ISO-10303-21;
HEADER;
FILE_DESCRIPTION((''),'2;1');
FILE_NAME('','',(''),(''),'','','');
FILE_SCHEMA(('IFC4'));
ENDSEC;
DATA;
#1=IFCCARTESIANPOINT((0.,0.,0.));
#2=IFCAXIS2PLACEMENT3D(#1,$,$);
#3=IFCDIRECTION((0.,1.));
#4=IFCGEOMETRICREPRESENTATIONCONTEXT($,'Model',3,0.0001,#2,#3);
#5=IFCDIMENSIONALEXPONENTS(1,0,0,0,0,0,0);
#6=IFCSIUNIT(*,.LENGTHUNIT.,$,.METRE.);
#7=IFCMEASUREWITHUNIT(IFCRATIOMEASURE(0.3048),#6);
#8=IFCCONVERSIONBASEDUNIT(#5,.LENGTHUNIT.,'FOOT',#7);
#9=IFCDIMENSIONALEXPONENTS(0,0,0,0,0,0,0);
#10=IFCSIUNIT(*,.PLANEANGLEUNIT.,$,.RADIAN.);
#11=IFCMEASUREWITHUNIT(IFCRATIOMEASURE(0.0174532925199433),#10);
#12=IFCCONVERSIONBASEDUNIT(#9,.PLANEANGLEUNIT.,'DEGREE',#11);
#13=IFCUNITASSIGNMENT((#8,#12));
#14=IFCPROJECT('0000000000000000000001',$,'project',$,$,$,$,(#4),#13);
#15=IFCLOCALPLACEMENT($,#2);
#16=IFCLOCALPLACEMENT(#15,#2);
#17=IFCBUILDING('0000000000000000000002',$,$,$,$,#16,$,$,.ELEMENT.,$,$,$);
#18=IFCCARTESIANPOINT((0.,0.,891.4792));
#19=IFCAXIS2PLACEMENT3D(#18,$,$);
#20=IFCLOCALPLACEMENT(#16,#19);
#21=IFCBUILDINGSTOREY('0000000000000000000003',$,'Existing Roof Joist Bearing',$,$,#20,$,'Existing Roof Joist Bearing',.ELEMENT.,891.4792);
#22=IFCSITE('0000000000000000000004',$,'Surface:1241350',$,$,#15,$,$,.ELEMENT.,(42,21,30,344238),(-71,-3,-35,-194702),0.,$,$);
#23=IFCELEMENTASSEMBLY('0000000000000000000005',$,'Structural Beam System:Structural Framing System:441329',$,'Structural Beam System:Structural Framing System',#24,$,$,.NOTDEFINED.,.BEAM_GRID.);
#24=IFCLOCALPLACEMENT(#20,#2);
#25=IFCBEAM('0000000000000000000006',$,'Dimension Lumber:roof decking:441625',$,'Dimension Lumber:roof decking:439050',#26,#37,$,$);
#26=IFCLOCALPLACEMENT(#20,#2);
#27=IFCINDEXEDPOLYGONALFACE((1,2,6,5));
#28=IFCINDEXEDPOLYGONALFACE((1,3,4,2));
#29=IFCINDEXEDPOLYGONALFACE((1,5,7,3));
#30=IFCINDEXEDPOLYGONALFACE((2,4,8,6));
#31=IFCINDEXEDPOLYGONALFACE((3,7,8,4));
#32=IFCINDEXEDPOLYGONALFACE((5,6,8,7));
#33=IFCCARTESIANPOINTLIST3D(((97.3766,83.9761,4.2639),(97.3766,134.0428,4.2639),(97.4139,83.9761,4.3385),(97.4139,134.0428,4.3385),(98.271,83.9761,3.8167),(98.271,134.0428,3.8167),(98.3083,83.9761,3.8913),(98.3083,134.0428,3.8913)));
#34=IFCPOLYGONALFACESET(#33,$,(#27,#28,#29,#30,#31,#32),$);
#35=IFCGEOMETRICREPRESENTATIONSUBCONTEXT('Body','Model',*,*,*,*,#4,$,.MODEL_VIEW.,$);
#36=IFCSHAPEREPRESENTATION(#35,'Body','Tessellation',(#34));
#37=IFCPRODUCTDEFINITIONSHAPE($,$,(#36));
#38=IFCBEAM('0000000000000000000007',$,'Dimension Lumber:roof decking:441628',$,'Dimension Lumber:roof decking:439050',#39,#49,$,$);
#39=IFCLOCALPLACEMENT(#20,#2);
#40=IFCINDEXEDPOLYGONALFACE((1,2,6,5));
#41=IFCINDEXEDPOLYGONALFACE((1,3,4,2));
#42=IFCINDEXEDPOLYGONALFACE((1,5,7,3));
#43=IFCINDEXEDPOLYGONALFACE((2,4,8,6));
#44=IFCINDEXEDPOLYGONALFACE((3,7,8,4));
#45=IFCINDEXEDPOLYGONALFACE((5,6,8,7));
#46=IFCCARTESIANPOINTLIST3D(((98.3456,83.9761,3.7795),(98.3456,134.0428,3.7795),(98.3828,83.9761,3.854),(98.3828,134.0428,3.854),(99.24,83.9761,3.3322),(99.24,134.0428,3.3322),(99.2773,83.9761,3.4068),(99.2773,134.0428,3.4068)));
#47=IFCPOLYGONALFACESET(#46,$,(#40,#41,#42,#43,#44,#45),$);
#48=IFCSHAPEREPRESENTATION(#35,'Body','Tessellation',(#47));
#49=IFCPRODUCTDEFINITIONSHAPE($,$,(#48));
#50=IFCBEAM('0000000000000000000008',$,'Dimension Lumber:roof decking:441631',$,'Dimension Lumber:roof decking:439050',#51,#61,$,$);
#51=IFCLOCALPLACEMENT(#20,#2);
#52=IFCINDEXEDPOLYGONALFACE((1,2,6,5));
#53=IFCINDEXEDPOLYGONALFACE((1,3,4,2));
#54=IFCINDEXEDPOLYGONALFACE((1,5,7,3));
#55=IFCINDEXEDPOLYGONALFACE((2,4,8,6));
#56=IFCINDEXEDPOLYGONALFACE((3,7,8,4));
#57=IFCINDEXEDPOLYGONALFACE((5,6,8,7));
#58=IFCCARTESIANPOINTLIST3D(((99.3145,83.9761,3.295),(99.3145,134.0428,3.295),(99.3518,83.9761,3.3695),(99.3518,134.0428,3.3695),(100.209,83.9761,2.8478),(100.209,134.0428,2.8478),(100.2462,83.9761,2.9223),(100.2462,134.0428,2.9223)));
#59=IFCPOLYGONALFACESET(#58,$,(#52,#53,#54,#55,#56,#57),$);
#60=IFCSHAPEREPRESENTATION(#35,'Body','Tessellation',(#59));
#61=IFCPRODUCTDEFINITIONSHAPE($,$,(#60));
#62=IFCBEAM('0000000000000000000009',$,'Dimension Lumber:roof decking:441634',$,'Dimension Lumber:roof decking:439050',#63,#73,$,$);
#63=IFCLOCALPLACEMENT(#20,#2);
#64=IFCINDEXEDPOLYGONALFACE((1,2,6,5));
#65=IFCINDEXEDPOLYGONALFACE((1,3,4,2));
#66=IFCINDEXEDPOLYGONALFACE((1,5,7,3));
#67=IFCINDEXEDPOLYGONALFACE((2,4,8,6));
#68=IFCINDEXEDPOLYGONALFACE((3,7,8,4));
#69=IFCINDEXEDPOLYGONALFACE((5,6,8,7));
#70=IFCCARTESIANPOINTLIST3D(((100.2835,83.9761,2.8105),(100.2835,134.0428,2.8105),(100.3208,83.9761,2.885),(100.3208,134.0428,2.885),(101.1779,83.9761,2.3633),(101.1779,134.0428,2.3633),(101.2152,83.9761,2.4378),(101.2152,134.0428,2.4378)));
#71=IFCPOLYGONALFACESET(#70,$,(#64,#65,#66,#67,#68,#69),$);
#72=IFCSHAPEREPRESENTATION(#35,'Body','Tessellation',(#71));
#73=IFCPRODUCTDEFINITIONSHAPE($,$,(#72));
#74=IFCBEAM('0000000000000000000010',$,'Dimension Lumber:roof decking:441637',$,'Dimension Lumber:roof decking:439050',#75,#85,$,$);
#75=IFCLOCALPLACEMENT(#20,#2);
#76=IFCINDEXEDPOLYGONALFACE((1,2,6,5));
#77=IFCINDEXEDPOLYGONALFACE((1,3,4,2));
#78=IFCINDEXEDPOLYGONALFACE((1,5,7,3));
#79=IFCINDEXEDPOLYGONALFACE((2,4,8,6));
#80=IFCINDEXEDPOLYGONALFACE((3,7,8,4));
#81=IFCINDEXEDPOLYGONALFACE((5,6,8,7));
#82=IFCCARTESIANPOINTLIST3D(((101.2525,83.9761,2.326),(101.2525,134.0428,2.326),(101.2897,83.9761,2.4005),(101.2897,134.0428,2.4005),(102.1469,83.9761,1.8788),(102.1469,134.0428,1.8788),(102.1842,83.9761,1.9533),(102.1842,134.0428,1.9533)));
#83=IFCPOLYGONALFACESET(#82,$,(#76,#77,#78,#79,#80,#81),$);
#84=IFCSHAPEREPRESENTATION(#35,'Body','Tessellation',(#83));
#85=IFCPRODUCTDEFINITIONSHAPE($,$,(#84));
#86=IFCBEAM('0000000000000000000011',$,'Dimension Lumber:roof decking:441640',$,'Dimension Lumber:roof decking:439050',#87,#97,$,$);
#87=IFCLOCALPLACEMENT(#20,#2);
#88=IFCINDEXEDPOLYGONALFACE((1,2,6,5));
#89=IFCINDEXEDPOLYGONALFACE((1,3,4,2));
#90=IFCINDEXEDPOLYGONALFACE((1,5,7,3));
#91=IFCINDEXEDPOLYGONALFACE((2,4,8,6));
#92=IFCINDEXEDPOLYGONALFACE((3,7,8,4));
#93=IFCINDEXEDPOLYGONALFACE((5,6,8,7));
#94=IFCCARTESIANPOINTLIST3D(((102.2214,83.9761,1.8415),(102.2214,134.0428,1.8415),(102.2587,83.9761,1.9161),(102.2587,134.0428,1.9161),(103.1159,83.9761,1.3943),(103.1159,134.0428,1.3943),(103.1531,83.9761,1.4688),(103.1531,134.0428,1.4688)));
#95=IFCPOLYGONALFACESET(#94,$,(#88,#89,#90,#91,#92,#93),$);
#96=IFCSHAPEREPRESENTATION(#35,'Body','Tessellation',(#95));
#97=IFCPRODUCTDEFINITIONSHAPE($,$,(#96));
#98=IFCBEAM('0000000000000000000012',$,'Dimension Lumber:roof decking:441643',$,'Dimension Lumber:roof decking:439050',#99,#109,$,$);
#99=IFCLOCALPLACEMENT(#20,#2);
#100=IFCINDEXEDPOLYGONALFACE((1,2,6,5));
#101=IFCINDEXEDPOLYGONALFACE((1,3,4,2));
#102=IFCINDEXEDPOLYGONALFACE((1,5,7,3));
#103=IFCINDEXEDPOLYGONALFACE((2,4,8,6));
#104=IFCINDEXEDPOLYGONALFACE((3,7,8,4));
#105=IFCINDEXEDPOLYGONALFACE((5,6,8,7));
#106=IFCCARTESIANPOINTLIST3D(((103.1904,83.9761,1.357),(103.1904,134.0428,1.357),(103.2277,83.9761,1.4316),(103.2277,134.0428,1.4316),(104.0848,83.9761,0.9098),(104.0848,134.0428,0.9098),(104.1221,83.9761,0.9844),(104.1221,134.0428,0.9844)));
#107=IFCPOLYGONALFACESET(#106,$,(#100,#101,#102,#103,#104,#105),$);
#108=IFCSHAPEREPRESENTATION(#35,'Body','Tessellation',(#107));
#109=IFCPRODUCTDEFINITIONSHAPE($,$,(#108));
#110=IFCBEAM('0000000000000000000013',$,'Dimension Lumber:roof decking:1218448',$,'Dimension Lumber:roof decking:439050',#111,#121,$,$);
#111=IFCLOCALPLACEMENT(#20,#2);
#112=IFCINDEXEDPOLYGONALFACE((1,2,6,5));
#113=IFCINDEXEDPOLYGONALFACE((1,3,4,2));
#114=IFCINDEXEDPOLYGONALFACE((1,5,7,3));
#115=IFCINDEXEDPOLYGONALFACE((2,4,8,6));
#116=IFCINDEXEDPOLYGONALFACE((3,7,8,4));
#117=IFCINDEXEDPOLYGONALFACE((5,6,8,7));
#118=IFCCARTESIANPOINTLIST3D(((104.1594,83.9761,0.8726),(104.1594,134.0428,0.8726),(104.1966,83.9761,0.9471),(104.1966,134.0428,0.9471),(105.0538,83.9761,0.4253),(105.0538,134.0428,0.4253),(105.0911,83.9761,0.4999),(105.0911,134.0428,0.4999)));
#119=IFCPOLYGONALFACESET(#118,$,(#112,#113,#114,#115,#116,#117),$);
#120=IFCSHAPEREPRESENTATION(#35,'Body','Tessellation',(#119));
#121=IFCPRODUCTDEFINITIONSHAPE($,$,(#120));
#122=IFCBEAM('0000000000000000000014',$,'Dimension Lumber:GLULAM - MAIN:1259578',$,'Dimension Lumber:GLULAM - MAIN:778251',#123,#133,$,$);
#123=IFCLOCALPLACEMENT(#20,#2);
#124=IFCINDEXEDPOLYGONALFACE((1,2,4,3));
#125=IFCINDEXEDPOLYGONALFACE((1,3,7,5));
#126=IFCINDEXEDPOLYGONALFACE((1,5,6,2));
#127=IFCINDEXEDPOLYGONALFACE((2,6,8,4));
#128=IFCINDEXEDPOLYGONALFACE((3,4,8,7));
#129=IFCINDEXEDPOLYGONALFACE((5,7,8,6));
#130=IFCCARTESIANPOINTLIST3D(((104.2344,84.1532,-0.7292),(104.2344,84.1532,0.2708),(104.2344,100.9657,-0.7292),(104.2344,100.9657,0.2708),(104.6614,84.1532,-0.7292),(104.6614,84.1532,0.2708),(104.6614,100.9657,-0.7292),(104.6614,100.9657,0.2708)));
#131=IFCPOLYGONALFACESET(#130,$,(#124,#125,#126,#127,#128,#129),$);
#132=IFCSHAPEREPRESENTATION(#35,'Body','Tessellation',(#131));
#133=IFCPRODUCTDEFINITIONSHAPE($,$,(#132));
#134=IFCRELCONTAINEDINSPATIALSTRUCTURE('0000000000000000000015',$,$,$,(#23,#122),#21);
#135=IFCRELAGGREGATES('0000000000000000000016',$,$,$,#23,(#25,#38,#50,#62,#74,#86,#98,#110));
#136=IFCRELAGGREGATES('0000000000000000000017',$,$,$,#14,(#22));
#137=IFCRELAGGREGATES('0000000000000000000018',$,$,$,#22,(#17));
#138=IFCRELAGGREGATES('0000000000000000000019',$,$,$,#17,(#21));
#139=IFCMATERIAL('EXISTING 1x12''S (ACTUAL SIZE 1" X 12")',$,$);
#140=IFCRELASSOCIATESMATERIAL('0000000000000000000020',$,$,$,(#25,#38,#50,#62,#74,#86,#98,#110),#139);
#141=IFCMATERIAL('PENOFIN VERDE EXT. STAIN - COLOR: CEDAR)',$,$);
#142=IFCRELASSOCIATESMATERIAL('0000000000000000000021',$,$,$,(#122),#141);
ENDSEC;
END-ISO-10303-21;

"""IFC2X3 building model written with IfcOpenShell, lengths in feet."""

from ifc_helpers import new_model, entity, si_unit, converted_unit, direction, frame, frame_2d, origin, origin_2d_with_axis, place, context, subcontext, project, spatial, rectangle, extrude, material, element, aggregate, save


model = new_model("IFC2X3")

# Units and contexts
model_context = context("Model", 3, precision=0.0001, world=origin(), true_north=direction((0.0, 1.0)))
body_context = subcontext(model_context, "Body", "Model", "MODEL_VIEW")
ifc_project = project(units=[converted_unit("LENGTHUNIT", "FOOT", entity("IfcRatioMeasure", 0.3048), si_unit("LENGTHUNIT", "METRE"), dimensions=[1, 0, 0, 0, 0, 0, 0]), converted_unit("PLANEANGLEUNIT", "DEGREE", entity("IfcRatioMeasure", 0.0174532925199433), si_unit("PLANEANGLEUNIT", "RADIAN"), dimensions=[0, 0, 0, 0, 0, 0, 0])], contexts=[model_context])

# Site, building, storey
site_placement = place(None, origin())
site = spatial("IfcSite", under=ifc_project, at=site_placement, Name="Surface:1241350", CompositionType="ELEMENT", RefLatitude=(42, 21, 30, 344238), RefLongitude=(-71, -3, -35, -194702), RefElevation=0.0)
building_placement = place(site_placement, origin())
building = spatial("IfcBuilding", under=site, at=building_placement, CompositionType="ELEMENT")
storey_placement = place(building_placement, frame((0.0, 0.0, 891.4792)))
storey = spatial("IfcBuildingStorey", under=building, at=storey_placement, Name="Existing Roof Joist Bearing", LongName="Existing Roof Joist Bearing", CompositionType="ELEMENT", Elevation=891.4792)

# Element assembly, beams
assembly_1_placement = place(storey_placement, origin())
assembly_1 = element("IfcElementAssembly", 1, at=assembly_1_placement, inside=storey, Name="Structural Beam System:Structural Framing System:441329", ObjectType="Structural Beam System:Structural Framing System", AssemblyPlace="NOTDEFINED", PredefinedType="BEAM_GRID")
ifc_material_1 = material(Name="EXISTING 1x12'S (ACTUAL SIZE 1\" X 12\")")
beam_1_placement = place(assembly_1_placement, frame((97.8611, 83.9761, 4.1149), z_axis=(0.0, 0.0, 1.0), x_axis=(0.0, 1.0, 0.0)))
beam_1 = element("IfcBeam", 2, at=beam_1_placement, material=ifc_material_1, Name="Dimension Lumber:roof decking:441625", ObjectType="Dimension Lumber:roof decking:439050", context=body_context, shape_type="SweptSolid", body=[
    extrude(rectangle(XDim=0.0833, YDim=1.0, at=frame_2d((0.0, 0.0), x_axis=(0.0, 1.0))), frame((0.0, 0.0186, -0.0373), z_axis=(1.0, 0.0, 0.0), x_axis=(0.0, -0.894427, -0.447214)), (0.0, 0.0, 1.0), 50.0667),
])
beam_2_placement = place(assembly_1_placement, frame((98.8301, 83.9761, 3.6304), z_axis=(0.0, 0.0, 1.0), x_axis=(0.0, 1.0, 0.0)))
beam_2 = element("IfcBeam", 3, at=beam_2_placement, material=ifc_material_1, Name="Dimension Lumber:roof decking:441628", ObjectType="Dimension Lumber:roof decking:439050", context=body_context, shape_type="SweptSolid", body=[
    extrude(rectangle(XDim=0.0833, YDim=1.0, at=frame_2d((0.0, 0.0), x_axis=(0.0, 1.0))), frame((0.0, 0.0186, -0.0373), z_axis=(1.0, 0.0, 0.0), x_axis=(0.0, -0.894427, -0.447214)), (0.0, 0.0, 1.0), 50.0667),
])
beam_3_placement = place(assembly_1_placement, frame((99.799, 83.9761, 3.1459), z_axis=(0.0, 0.0, 1.0), x_axis=(0.0, 1.0, 0.0)))
beam_3 = element("IfcBeam", 4, at=beam_3_placement, material=ifc_material_1, Name="Dimension Lumber:roof decking:441631", ObjectType="Dimension Lumber:roof decking:439050", context=body_context, shape_type="SweptSolid", body=[
    extrude(rectangle(XDim=0.0833, YDim=1.0, at=frame_2d((0.0, 0.0), x_axis=(0.0, 1.0))), frame((0.0, 0.0186, -0.0373), z_axis=(1.0, 0.0, 0.0), x_axis=(0.0, -0.894427, -0.447214)), (0.0, 0.0, 1.0), 50.0667),
])
beam_4_placement = place(assembly_1_placement, frame((100.768, 83.9761, 2.6614), z_axis=(0.0, 0.0, 1.0), x_axis=(0.0, 1.0, 0.0)))
beam_4 = element("IfcBeam", 5, at=beam_4_placement, material=ifc_material_1, Name="Dimension Lumber:roof decking:441634", ObjectType="Dimension Lumber:roof decking:439050", context=body_context, shape_type="SweptSolid", body=[
    extrude(rectangle(XDim=0.0833, YDim=1.0, at=frame_2d((0.0, 0.0), x_axis=(0.0, 1.0))), frame((0.0, 0.0186, -0.0373), z_axis=(1.0, 0.0, 0.0), x_axis=(0.0, -0.894427, -0.447214)), (0.0, 0.0, 1.0), 50.0667),
])
beam_5_placement = place(assembly_1_placement, frame((101.737, 83.9761, 2.1769), z_axis=(0.0, 0.0, 1.0), x_axis=(0.0, 1.0, 0.0)))
beam_5 = element("IfcBeam", 6, at=beam_5_placement, material=ifc_material_1, Name="Dimension Lumber:roof decking:441637", ObjectType="Dimension Lumber:roof decking:439050", context=body_context, shape_type="SweptSolid", body=[
    extrude(rectangle(XDim=0.0833, YDim=1.0, at=frame_2d((0.0, 0.0), x_axis=(0.0, 1.0))), frame((0.0, 0.0186, -0.0373), z_axis=(1.0, 0.0, 0.0), x_axis=(0.0, -0.894427, -0.447214)), (0.0, 0.0, 1.0), 50.0667),
])
beam_6_placement = place(assembly_1_placement, frame((102.7059, 83.9761, 1.6925), z_axis=(0.0, 0.0, 1.0), x_axis=(0.0, 1.0, 0.0)))
beam_6 = element("IfcBeam", 7, at=beam_6_placement, material=ifc_material_1, Name="Dimension Lumber:roof decking:441640", ObjectType="Dimension Lumber:roof decking:439050", context=body_context, shape_type="SweptSolid", body=[
    extrude(rectangle(XDim=0.0833, YDim=1.0, at=frame_2d((0.0, 0.0), x_axis=(0.0, 1.0))), frame((0.0, 0.0186, -0.0373), z_axis=(1.0, 0.0, 0.0), x_axis=(0.0, -0.894427, -0.447214)), (0.0, 0.0, 1.0), 50.0667),
])
beam_7_placement = place(assembly_1_placement, frame((103.6749, 83.9761, 1.208), z_axis=(0.0, 0.0, 1.0), x_axis=(0.0, 1.0, 0.0)))
beam_7 = element("IfcBeam", 8, at=beam_7_placement, material=ifc_material_1, Name="Dimension Lumber:roof decking:441643", ObjectType="Dimension Lumber:roof decking:439050", context=body_context, shape_type="SweptSolid", body=[
    extrude(rectangle(XDim=0.0833, YDim=1.0, at=frame_2d((0.0, 0.0), x_axis=(0.0, 1.0))), frame((0.0, 0.0186, -0.0373), z_axis=(1.0, 0.0, 0.0), x_axis=(0.0, -0.894427, -0.447214)), (0.0, 0.0, 1.0), 50.0667),
])
beam_8_placement = place(assembly_1_placement, frame((104.6438, 83.9761, 0.7235), z_axis=(0.0, 0.0, 1.0), x_axis=(0.0, 1.0, 0.0)))
beam_8 = element("IfcBeam", 9, at=beam_8_placement, material=ifc_material_1, Name="Dimension Lumber:roof decking:1218448", ObjectType="Dimension Lumber:roof decking:439050", context=body_context, shape_type="SweptSolid", body=[
    extrude(rectangle(XDim=0.0833, YDim=1.0, at=frame_2d((0.0, 0.0), x_axis=(0.0, 1.0))), frame((0.0, 0.0186, -0.0373), z_axis=(1.0, 0.0, 0.0), x_axis=(0.0, -0.894427, -0.447214)), (0.0, 0.0, 1.0), 50.0667),
])
aggregate(assembly_1, [beam_1, beam_2, beam_3, beam_4, beam_5, beam_6, beam_7, beam_8])

# Beam
ifc_material_2 = material(Name="PENOFIN VERDE EXT. STAIN - COLOR: CEDAR)")
beam_9_placement = place(storey_placement, frame((104.4479, 100.9657, 0.0), z_axis=(0.0, 0.0, 1.0), x_axis=(0.0, -1.0, 0.0)))
element("IfcBeam", 10, at=beam_9_placement, inside=storey, material=ifc_material_2, Name="Dimension Lumber:GLULAM - MAIN:1259578", ObjectType="Dimension Lumber:GLULAM - MAIN:778251", context=body_context, shape_type="SweptSolid", body=[
    extrude(rectangle(XDim=1.0, YDim=0.4271, at=origin_2d_with_axis()), frame((0.0, 0.0, -0.2292), z_axis=(1.0, 0.0, 0.0), x_axis=(0.0, 0.0, -1.0)), (0.0, 0.0, 1.0), 16.8125),
])

save(model, "model.ifc")
